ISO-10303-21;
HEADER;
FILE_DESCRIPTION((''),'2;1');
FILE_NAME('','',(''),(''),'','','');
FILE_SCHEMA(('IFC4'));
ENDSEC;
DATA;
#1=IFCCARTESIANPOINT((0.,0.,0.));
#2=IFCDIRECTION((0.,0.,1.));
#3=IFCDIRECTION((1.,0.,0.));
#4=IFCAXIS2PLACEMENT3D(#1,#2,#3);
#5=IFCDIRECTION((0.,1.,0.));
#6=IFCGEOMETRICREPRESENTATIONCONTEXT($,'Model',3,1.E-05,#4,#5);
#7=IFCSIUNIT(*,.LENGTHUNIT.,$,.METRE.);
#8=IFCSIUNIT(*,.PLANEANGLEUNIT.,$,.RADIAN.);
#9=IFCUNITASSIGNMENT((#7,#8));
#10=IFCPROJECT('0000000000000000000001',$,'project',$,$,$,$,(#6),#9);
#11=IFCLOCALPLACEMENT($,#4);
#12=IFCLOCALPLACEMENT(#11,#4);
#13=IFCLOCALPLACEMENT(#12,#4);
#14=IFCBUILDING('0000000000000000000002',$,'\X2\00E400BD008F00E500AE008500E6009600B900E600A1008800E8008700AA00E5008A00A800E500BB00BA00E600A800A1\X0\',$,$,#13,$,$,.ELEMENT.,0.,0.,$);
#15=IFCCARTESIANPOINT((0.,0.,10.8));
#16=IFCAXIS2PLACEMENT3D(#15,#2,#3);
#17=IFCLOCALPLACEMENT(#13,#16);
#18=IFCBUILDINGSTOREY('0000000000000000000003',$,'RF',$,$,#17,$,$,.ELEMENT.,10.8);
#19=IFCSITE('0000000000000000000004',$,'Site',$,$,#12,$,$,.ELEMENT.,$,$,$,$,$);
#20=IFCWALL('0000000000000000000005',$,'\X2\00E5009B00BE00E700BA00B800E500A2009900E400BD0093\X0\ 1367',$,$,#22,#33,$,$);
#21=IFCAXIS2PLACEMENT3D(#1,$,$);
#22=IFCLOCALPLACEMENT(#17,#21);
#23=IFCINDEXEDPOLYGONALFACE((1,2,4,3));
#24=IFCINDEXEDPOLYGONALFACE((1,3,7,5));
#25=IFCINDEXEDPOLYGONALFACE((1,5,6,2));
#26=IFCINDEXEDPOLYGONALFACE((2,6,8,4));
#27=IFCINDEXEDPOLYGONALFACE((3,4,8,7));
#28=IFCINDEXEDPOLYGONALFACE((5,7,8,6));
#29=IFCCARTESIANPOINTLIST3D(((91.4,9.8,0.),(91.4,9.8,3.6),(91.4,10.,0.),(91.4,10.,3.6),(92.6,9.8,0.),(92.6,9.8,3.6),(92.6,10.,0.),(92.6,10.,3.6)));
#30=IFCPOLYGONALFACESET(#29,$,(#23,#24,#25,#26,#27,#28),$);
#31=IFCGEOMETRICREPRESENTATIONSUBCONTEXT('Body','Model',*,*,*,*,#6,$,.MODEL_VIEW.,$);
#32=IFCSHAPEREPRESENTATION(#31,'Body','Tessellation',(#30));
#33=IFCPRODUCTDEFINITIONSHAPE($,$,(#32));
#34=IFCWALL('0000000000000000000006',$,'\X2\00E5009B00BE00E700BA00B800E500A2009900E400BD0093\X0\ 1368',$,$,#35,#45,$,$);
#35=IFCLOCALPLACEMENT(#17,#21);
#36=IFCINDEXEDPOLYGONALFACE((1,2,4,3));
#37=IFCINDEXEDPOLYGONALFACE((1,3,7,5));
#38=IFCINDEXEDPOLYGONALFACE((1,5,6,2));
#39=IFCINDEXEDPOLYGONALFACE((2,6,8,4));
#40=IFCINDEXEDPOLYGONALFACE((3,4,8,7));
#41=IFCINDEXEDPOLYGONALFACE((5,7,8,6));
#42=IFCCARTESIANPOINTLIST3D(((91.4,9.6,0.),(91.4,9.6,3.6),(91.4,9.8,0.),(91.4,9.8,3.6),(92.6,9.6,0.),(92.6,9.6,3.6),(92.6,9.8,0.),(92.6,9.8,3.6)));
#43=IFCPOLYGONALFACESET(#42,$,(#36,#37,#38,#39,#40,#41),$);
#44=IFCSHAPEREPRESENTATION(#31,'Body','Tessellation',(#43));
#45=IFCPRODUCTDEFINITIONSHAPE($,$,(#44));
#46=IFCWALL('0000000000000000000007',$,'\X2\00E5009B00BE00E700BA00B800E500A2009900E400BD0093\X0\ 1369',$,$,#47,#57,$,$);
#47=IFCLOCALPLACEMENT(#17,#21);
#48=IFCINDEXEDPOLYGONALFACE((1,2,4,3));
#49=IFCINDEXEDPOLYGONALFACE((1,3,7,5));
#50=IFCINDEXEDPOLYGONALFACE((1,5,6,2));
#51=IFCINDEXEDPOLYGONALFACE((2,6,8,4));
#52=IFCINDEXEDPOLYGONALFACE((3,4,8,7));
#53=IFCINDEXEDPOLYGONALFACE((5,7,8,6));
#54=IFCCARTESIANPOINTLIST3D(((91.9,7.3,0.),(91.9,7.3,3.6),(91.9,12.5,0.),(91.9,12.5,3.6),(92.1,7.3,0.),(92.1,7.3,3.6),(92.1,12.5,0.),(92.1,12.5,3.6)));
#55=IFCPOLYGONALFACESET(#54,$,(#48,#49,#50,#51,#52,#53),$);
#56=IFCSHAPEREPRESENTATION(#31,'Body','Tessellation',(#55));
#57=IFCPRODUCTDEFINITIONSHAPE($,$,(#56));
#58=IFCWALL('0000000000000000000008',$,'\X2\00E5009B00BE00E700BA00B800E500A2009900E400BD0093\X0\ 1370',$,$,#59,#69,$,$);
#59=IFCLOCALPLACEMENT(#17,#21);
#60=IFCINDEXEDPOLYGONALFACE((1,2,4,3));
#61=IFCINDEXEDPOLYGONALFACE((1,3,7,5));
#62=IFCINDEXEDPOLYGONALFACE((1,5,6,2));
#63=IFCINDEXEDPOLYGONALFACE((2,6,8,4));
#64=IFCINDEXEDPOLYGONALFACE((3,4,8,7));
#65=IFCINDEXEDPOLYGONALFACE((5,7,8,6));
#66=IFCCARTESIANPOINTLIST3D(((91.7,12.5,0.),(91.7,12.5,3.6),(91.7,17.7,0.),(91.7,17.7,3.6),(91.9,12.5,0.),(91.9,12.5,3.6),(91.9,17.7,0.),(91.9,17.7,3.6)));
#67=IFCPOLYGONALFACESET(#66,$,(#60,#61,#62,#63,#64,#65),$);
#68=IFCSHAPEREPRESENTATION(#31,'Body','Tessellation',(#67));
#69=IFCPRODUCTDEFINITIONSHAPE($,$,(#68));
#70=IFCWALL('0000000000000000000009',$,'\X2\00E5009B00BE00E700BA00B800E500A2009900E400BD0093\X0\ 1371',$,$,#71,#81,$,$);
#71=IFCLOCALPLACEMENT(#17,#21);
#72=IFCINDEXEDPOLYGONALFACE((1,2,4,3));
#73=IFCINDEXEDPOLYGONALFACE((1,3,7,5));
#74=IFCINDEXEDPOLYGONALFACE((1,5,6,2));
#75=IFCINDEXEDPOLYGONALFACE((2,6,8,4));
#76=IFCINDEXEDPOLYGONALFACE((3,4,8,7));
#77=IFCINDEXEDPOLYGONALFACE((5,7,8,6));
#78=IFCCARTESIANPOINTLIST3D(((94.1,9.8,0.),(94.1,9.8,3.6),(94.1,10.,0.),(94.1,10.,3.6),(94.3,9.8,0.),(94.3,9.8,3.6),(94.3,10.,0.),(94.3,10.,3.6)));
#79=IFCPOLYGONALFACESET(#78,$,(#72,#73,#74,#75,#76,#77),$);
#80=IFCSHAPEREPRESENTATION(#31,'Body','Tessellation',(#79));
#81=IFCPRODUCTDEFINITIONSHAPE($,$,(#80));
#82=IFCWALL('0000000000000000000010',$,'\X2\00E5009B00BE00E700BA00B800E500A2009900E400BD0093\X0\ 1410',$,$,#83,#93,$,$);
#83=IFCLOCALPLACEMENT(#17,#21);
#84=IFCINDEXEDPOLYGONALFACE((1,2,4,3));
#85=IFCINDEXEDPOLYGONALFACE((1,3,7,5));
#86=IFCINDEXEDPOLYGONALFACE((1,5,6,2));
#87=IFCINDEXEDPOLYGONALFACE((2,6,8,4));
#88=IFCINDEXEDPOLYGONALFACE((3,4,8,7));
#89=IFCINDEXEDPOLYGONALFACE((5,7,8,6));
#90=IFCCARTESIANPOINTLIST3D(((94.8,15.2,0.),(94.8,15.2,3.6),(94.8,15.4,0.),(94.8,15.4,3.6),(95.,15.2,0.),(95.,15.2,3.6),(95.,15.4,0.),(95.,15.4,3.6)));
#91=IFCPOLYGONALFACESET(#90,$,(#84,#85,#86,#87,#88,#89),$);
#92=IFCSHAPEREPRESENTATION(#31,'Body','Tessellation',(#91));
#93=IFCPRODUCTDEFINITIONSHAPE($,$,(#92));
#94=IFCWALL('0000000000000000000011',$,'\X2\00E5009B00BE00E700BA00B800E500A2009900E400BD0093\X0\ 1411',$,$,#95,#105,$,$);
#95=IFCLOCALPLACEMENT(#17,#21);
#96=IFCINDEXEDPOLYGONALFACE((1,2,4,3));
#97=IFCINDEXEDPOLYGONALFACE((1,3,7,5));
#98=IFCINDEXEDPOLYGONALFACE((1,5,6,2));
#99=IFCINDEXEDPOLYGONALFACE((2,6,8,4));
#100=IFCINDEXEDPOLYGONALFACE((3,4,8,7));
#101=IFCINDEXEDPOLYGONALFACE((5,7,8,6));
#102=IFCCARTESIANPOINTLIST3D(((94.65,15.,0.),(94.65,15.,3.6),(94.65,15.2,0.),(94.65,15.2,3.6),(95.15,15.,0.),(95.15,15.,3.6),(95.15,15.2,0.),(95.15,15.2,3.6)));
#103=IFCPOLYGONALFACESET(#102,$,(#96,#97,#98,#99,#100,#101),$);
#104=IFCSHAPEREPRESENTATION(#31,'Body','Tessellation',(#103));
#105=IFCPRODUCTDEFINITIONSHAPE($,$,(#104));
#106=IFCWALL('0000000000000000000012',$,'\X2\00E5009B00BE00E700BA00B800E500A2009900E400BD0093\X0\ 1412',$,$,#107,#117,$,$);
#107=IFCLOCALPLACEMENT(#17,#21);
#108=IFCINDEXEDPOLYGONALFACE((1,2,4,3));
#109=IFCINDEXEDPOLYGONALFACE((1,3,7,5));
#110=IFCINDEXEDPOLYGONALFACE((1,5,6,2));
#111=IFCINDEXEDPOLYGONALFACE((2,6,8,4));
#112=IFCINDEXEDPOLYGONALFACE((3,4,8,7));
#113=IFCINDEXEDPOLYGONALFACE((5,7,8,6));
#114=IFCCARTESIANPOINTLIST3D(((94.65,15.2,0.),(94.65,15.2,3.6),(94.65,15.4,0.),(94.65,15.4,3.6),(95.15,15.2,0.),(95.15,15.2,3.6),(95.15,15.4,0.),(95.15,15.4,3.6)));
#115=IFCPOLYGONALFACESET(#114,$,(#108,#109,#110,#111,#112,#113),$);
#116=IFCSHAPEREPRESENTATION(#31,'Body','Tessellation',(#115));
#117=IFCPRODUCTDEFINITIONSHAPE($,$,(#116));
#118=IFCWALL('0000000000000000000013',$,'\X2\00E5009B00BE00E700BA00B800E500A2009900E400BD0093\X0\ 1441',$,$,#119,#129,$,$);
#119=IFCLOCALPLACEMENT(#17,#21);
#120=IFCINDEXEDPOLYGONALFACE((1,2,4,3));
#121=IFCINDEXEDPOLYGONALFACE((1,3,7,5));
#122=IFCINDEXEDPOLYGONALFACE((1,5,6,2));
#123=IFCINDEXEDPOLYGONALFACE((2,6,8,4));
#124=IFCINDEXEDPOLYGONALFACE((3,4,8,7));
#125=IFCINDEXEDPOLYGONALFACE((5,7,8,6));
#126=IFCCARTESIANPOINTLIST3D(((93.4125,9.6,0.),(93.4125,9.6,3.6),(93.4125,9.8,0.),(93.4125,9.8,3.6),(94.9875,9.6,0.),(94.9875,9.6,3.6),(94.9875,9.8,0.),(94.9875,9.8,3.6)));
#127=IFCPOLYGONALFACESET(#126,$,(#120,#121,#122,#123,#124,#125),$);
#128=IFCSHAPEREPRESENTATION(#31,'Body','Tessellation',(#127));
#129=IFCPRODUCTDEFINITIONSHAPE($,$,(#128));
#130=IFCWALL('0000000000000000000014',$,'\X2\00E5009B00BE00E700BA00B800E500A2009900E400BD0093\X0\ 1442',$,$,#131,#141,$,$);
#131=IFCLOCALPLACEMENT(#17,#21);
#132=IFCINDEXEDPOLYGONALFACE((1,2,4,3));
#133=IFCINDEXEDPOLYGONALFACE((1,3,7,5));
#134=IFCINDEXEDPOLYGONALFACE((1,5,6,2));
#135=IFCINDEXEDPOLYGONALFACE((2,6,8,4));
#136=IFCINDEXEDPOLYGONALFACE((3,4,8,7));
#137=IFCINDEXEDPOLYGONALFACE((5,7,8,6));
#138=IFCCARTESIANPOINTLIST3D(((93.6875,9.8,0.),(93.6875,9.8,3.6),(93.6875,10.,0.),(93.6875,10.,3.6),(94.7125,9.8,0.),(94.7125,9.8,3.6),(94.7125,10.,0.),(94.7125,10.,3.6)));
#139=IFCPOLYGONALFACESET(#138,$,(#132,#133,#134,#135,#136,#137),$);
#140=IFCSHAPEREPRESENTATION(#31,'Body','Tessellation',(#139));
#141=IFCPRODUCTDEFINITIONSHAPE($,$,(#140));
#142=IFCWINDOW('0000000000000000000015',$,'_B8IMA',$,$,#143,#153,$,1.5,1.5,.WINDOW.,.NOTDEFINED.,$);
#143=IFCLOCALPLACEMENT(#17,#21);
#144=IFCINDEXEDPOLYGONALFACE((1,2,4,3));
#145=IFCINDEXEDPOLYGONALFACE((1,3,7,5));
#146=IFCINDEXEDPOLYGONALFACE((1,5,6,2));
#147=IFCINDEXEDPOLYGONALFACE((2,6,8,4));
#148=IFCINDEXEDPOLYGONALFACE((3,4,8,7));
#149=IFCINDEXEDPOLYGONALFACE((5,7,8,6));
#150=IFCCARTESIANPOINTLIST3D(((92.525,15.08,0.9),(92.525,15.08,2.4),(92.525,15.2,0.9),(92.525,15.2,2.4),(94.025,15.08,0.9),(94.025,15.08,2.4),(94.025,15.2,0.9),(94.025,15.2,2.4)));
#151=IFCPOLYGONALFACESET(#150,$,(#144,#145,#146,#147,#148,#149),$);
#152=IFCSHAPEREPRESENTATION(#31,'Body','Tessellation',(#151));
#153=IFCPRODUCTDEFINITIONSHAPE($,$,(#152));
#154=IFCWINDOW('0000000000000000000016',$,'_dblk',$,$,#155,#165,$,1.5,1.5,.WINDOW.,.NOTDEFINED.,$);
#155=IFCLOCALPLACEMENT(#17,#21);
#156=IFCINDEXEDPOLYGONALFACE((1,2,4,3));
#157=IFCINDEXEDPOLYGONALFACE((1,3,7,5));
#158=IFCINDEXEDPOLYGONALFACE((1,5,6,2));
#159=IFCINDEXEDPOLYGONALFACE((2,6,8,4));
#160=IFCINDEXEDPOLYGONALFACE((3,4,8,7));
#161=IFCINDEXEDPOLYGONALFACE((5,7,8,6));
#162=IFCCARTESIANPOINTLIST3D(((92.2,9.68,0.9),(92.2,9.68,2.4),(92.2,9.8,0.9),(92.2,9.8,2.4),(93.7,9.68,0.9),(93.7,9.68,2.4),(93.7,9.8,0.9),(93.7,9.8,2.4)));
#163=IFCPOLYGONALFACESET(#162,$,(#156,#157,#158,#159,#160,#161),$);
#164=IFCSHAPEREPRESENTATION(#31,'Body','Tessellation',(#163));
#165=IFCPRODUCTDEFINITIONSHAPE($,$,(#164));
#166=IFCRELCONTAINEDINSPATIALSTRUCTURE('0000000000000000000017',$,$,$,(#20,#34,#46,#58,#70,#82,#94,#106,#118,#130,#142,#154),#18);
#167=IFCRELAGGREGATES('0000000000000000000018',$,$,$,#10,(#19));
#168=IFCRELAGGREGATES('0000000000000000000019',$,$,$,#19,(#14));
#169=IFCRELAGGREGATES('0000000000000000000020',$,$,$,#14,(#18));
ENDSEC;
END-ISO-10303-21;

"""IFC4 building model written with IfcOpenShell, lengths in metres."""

from ifc_helpers import new_model, si_unit, direction, frame, frame_2d, origin_with_axes, place, context, subcontext, project, spatial, rectangle, extrude, element, save


model = new_model("IFC4")

# Units and contexts
model_context = context("Model", 3, precision=1e-05, world=origin_with_axes(), true_north=direction((0.0, 1.0, 0.0)))
body_context = subcontext(model_context, "Body", "Model", "MODEL_VIEW")
ifc_project = project(units=[si_unit("LENGTHUNIT", "METRE"), si_unit("PLANEANGLEUNIT", "RADIAN")], contexts=[model_context])

# Site, building, storey
placement = place(None, origin_with_axes())
site_placement = place(placement, origin_with_axes())
site = spatial("IfcSite", under=ifc_project, at=site_placement, Name="Site", CompositionType="ELEMENT")
building_placement = place(site_placement, origin_with_axes())
building = spatial("IfcBuilding", under=site, at=building_placement, Name="ä½\u008få®\u0085æ\u0096¹æ¡\u0088è\u0087ªå\u008a¨å»ºæ¨¡", CompositionType="ELEMENT", ElevationOfRefHeight=0.0, ElevationOfTerrain=0.0)
storey_placement = place(building_placement, frame((0.0, 0.0, 10.8), z_axis=(0.0, 0.0, 1.0), x_axis=(1.0, 0.0, 0.0)))
storey = spatial("IfcBuildingStorey", under=building, at=storey_placement, Name="RF", CompositionType="ELEMENT", Elevation=10.8)

# Walls
for number, where, z_axis, x_axis, name in (
    (1, (92.0, 9.9, 0.0), (0.0, 0.0, 1.0), (1.0, 0.0, 0.0), "å\u009b¾çº¸å¢\u0099ä½\u0093 1367"),
    (2, (92.0, 9.7, 0.0), (0.0, 0.0, 1.0), (1.0, 0.0, 0.0), "å\u009b¾çº¸å¢\u0099ä½\u0093 1368"),
):
    element("IfcWall", number, at=place(storey_placement, frame(where, z_axis=z_axis, x_axis=x_axis)), inside=storey, Name=name, context=body_context, shape_type="SweptSolid", body=[
        extrude(rectangle(XDim=1.2, YDim=0.2, at=frame_2d((0.0, 0.0), x_axis=(1.0, 0.0, 0.0))), frame((0.0, 0.0, 0.0), z_axis=(0.0, 0.0, 1.0)), (0.0, 0.0, 1.0), 3.6),
    ])
for number, where, z_axis, x_axis, name in (
    (3, (92.0, 9.9, 0.0), (0.0, 0.0, 1.0), (0.0, 1.0, 0.0), "å\u009b¾çº¸å¢\u0099ä½\u0093 1369"),
    (4, (91.8, 15.1, 0.0), (0.0, 0.0, 1.0), (0.0, -1.0, 0.0), "å\u009b¾çº¸å¢\u0099ä½\u0093 1370"),
):
    element("IfcWall", number, at=place(storey_placement, frame(where, z_axis=z_axis, x_axis=x_axis)), inside=storey, Name=name, context=body_context, shape_type="SweptSolid", body=[
        extrude(rectangle(XDim=5.2, YDim=0.2, at=frame_2d((0.0, 0.0), x_axis=(1.0, 0.0, 0.0))), frame((0.0, 0.0, 0.0), z_axis=(0.0, 0.0, 1.0)), (0.0, 0.0, 1.0), 3.6),
    ])
for number, where, z_axis, x_axis, name in (
    (5, (94.2, 9.9, 0.0), (0.0, 0.0, 1.0), (0.0, -1.0, 0.0), "å\u009b¾çº¸å¢\u0099ä½\u0093 1371"),
    (6, (94.9, 15.3, 0.0), (0.0, 0.0, 1.0), (0.0, -1.0, 0.0), "å\u009b¾çº¸å¢\u0099ä½\u0093 1410"),
):
    element("IfcWall", number, at=place(storey_placement, frame(where, z_axis=z_axis, x_axis=x_axis)), inside=storey, Name=name, context=body_context, shape_type="SweptSolid", body=[
        extrude(rectangle(XDim=0.2, YDim=0.2, at=frame_2d((0.0, 0.0), x_axis=(1.0, 0.0, 0.0))), frame((0.0, 0.0, 0.0), z_axis=(0.0, 0.0, 1.0)), (0.0, 0.0, 1.0), 3.6),
    ])
for number, where, z_axis, x_axis, name in (
    (7, (94.9, 15.1, 0.0), (0.0, 0.0, 1.0), (1.0, 0.0, 0.0), "å\u009b¾çº¸å¢\u0099ä½\u0093 1411"),
    (8, (94.9, 15.3, 0.0), (0.0, 0.0, 1.0), (1.0, 0.0, 0.0), "å\u009b¾çº¸å¢\u0099ä½\u0093 1412"),
):
    element("IfcWall", number, at=place(storey_placement, frame(where, z_axis=z_axis, x_axis=x_axis)), inside=storey, Name=name, context=body_context, shape_type="SweptSolid", body=[
        extrude(rectangle(XDim=0.5, YDim=0.2, at=frame_2d((0.0, 0.0), x_axis=(1.0, 0.0, 0.0))), frame((0.0, 0.0, 0.0), z_axis=(0.0, 0.0, 1.0)), (0.0, 0.0, 1.0), 3.6),
    ])
wall_1_placement = place(storey_placement, frame((94.2, 9.7, 0.0), z_axis=(0.0, 0.0, 1.0), x_axis=(1.0, 0.0, 0.0)))
element("IfcWall", 9, at=wall_1_placement, inside=storey, Name="å\u009b¾çº¸å¢\u0099ä½\u0093 1441", context=body_context, shape_type="SweptSolid", body=[
    extrude(rectangle(XDim=1.575, YDim=0.2, at=frame_2d((0.0, 0.0), x_axis=(1.0, 0.0, 0.0))), frame((0.0, 0.0, 0.0), z_axis=(0.0, 0.0, 1.0)), (0.0, 0.0, 1.0), 3.6),
])
wall_2_placement = place(storey_placement, frame((94.2, 9.9, 0.0), z_axis=(0.0, 0.0, 1.0), x_axis=(1.0, 0.0, 0.0)))
element("IfcWall", 10, at=wall_2_placement, inside=storey, Name="å\u009b¾çº¸å¢\u0099ä½\u0093 1442", context=body_context, shape_type="SweptSolid", body=[
    extrude(rectangle(XDim=1.025, YDim=0.2, at=frame_2d((0.0, 0.0), x_axis=(1.0, 0.0, 0.0))), frame((0.0, 0.0, 0.0), z_axis=(0.0, 0.0, 1.0)), (0.0, 0.0, 1.0), 3.6),
])

# Windows
for number, where, z_axis, x_axis, name in (
    (11, (93.275, 15.14, 0.9), (0.0, 0.0, 1.0), (1.0, 0.0, 0.0), "_B8IMA"),
    (12, (92.95, 9.74, 0.9), (0.0, 0.0, 1.0), (1.0, 0.0, 0.0), "_dblk"),
):
    element("IfcWindow", number, at=place(storey_placement, frame(where, z_axis=z_axis, x_axis=x_axis)), inside=storey, Name=name, OverallHeight=1.5, OverallWidth=1.5, PartitioningType="NOTDEFINED", PredefinedType="WINDOW", context=body_context, shape_type="SweptSolid", body=[
        extrude(rectangle(XDim=1.5, YDim=0.12, at=frame_2d((0.0, 0.0), x_axis=(1.0, 0.0, 0.0))), frame((0.0, 0.0, 0.0), z_axis=(0.0, 0.0, 1.0)), (0.0, 0.0, 1.0), 1.5),
    ])

save(model, "model.ifc")
